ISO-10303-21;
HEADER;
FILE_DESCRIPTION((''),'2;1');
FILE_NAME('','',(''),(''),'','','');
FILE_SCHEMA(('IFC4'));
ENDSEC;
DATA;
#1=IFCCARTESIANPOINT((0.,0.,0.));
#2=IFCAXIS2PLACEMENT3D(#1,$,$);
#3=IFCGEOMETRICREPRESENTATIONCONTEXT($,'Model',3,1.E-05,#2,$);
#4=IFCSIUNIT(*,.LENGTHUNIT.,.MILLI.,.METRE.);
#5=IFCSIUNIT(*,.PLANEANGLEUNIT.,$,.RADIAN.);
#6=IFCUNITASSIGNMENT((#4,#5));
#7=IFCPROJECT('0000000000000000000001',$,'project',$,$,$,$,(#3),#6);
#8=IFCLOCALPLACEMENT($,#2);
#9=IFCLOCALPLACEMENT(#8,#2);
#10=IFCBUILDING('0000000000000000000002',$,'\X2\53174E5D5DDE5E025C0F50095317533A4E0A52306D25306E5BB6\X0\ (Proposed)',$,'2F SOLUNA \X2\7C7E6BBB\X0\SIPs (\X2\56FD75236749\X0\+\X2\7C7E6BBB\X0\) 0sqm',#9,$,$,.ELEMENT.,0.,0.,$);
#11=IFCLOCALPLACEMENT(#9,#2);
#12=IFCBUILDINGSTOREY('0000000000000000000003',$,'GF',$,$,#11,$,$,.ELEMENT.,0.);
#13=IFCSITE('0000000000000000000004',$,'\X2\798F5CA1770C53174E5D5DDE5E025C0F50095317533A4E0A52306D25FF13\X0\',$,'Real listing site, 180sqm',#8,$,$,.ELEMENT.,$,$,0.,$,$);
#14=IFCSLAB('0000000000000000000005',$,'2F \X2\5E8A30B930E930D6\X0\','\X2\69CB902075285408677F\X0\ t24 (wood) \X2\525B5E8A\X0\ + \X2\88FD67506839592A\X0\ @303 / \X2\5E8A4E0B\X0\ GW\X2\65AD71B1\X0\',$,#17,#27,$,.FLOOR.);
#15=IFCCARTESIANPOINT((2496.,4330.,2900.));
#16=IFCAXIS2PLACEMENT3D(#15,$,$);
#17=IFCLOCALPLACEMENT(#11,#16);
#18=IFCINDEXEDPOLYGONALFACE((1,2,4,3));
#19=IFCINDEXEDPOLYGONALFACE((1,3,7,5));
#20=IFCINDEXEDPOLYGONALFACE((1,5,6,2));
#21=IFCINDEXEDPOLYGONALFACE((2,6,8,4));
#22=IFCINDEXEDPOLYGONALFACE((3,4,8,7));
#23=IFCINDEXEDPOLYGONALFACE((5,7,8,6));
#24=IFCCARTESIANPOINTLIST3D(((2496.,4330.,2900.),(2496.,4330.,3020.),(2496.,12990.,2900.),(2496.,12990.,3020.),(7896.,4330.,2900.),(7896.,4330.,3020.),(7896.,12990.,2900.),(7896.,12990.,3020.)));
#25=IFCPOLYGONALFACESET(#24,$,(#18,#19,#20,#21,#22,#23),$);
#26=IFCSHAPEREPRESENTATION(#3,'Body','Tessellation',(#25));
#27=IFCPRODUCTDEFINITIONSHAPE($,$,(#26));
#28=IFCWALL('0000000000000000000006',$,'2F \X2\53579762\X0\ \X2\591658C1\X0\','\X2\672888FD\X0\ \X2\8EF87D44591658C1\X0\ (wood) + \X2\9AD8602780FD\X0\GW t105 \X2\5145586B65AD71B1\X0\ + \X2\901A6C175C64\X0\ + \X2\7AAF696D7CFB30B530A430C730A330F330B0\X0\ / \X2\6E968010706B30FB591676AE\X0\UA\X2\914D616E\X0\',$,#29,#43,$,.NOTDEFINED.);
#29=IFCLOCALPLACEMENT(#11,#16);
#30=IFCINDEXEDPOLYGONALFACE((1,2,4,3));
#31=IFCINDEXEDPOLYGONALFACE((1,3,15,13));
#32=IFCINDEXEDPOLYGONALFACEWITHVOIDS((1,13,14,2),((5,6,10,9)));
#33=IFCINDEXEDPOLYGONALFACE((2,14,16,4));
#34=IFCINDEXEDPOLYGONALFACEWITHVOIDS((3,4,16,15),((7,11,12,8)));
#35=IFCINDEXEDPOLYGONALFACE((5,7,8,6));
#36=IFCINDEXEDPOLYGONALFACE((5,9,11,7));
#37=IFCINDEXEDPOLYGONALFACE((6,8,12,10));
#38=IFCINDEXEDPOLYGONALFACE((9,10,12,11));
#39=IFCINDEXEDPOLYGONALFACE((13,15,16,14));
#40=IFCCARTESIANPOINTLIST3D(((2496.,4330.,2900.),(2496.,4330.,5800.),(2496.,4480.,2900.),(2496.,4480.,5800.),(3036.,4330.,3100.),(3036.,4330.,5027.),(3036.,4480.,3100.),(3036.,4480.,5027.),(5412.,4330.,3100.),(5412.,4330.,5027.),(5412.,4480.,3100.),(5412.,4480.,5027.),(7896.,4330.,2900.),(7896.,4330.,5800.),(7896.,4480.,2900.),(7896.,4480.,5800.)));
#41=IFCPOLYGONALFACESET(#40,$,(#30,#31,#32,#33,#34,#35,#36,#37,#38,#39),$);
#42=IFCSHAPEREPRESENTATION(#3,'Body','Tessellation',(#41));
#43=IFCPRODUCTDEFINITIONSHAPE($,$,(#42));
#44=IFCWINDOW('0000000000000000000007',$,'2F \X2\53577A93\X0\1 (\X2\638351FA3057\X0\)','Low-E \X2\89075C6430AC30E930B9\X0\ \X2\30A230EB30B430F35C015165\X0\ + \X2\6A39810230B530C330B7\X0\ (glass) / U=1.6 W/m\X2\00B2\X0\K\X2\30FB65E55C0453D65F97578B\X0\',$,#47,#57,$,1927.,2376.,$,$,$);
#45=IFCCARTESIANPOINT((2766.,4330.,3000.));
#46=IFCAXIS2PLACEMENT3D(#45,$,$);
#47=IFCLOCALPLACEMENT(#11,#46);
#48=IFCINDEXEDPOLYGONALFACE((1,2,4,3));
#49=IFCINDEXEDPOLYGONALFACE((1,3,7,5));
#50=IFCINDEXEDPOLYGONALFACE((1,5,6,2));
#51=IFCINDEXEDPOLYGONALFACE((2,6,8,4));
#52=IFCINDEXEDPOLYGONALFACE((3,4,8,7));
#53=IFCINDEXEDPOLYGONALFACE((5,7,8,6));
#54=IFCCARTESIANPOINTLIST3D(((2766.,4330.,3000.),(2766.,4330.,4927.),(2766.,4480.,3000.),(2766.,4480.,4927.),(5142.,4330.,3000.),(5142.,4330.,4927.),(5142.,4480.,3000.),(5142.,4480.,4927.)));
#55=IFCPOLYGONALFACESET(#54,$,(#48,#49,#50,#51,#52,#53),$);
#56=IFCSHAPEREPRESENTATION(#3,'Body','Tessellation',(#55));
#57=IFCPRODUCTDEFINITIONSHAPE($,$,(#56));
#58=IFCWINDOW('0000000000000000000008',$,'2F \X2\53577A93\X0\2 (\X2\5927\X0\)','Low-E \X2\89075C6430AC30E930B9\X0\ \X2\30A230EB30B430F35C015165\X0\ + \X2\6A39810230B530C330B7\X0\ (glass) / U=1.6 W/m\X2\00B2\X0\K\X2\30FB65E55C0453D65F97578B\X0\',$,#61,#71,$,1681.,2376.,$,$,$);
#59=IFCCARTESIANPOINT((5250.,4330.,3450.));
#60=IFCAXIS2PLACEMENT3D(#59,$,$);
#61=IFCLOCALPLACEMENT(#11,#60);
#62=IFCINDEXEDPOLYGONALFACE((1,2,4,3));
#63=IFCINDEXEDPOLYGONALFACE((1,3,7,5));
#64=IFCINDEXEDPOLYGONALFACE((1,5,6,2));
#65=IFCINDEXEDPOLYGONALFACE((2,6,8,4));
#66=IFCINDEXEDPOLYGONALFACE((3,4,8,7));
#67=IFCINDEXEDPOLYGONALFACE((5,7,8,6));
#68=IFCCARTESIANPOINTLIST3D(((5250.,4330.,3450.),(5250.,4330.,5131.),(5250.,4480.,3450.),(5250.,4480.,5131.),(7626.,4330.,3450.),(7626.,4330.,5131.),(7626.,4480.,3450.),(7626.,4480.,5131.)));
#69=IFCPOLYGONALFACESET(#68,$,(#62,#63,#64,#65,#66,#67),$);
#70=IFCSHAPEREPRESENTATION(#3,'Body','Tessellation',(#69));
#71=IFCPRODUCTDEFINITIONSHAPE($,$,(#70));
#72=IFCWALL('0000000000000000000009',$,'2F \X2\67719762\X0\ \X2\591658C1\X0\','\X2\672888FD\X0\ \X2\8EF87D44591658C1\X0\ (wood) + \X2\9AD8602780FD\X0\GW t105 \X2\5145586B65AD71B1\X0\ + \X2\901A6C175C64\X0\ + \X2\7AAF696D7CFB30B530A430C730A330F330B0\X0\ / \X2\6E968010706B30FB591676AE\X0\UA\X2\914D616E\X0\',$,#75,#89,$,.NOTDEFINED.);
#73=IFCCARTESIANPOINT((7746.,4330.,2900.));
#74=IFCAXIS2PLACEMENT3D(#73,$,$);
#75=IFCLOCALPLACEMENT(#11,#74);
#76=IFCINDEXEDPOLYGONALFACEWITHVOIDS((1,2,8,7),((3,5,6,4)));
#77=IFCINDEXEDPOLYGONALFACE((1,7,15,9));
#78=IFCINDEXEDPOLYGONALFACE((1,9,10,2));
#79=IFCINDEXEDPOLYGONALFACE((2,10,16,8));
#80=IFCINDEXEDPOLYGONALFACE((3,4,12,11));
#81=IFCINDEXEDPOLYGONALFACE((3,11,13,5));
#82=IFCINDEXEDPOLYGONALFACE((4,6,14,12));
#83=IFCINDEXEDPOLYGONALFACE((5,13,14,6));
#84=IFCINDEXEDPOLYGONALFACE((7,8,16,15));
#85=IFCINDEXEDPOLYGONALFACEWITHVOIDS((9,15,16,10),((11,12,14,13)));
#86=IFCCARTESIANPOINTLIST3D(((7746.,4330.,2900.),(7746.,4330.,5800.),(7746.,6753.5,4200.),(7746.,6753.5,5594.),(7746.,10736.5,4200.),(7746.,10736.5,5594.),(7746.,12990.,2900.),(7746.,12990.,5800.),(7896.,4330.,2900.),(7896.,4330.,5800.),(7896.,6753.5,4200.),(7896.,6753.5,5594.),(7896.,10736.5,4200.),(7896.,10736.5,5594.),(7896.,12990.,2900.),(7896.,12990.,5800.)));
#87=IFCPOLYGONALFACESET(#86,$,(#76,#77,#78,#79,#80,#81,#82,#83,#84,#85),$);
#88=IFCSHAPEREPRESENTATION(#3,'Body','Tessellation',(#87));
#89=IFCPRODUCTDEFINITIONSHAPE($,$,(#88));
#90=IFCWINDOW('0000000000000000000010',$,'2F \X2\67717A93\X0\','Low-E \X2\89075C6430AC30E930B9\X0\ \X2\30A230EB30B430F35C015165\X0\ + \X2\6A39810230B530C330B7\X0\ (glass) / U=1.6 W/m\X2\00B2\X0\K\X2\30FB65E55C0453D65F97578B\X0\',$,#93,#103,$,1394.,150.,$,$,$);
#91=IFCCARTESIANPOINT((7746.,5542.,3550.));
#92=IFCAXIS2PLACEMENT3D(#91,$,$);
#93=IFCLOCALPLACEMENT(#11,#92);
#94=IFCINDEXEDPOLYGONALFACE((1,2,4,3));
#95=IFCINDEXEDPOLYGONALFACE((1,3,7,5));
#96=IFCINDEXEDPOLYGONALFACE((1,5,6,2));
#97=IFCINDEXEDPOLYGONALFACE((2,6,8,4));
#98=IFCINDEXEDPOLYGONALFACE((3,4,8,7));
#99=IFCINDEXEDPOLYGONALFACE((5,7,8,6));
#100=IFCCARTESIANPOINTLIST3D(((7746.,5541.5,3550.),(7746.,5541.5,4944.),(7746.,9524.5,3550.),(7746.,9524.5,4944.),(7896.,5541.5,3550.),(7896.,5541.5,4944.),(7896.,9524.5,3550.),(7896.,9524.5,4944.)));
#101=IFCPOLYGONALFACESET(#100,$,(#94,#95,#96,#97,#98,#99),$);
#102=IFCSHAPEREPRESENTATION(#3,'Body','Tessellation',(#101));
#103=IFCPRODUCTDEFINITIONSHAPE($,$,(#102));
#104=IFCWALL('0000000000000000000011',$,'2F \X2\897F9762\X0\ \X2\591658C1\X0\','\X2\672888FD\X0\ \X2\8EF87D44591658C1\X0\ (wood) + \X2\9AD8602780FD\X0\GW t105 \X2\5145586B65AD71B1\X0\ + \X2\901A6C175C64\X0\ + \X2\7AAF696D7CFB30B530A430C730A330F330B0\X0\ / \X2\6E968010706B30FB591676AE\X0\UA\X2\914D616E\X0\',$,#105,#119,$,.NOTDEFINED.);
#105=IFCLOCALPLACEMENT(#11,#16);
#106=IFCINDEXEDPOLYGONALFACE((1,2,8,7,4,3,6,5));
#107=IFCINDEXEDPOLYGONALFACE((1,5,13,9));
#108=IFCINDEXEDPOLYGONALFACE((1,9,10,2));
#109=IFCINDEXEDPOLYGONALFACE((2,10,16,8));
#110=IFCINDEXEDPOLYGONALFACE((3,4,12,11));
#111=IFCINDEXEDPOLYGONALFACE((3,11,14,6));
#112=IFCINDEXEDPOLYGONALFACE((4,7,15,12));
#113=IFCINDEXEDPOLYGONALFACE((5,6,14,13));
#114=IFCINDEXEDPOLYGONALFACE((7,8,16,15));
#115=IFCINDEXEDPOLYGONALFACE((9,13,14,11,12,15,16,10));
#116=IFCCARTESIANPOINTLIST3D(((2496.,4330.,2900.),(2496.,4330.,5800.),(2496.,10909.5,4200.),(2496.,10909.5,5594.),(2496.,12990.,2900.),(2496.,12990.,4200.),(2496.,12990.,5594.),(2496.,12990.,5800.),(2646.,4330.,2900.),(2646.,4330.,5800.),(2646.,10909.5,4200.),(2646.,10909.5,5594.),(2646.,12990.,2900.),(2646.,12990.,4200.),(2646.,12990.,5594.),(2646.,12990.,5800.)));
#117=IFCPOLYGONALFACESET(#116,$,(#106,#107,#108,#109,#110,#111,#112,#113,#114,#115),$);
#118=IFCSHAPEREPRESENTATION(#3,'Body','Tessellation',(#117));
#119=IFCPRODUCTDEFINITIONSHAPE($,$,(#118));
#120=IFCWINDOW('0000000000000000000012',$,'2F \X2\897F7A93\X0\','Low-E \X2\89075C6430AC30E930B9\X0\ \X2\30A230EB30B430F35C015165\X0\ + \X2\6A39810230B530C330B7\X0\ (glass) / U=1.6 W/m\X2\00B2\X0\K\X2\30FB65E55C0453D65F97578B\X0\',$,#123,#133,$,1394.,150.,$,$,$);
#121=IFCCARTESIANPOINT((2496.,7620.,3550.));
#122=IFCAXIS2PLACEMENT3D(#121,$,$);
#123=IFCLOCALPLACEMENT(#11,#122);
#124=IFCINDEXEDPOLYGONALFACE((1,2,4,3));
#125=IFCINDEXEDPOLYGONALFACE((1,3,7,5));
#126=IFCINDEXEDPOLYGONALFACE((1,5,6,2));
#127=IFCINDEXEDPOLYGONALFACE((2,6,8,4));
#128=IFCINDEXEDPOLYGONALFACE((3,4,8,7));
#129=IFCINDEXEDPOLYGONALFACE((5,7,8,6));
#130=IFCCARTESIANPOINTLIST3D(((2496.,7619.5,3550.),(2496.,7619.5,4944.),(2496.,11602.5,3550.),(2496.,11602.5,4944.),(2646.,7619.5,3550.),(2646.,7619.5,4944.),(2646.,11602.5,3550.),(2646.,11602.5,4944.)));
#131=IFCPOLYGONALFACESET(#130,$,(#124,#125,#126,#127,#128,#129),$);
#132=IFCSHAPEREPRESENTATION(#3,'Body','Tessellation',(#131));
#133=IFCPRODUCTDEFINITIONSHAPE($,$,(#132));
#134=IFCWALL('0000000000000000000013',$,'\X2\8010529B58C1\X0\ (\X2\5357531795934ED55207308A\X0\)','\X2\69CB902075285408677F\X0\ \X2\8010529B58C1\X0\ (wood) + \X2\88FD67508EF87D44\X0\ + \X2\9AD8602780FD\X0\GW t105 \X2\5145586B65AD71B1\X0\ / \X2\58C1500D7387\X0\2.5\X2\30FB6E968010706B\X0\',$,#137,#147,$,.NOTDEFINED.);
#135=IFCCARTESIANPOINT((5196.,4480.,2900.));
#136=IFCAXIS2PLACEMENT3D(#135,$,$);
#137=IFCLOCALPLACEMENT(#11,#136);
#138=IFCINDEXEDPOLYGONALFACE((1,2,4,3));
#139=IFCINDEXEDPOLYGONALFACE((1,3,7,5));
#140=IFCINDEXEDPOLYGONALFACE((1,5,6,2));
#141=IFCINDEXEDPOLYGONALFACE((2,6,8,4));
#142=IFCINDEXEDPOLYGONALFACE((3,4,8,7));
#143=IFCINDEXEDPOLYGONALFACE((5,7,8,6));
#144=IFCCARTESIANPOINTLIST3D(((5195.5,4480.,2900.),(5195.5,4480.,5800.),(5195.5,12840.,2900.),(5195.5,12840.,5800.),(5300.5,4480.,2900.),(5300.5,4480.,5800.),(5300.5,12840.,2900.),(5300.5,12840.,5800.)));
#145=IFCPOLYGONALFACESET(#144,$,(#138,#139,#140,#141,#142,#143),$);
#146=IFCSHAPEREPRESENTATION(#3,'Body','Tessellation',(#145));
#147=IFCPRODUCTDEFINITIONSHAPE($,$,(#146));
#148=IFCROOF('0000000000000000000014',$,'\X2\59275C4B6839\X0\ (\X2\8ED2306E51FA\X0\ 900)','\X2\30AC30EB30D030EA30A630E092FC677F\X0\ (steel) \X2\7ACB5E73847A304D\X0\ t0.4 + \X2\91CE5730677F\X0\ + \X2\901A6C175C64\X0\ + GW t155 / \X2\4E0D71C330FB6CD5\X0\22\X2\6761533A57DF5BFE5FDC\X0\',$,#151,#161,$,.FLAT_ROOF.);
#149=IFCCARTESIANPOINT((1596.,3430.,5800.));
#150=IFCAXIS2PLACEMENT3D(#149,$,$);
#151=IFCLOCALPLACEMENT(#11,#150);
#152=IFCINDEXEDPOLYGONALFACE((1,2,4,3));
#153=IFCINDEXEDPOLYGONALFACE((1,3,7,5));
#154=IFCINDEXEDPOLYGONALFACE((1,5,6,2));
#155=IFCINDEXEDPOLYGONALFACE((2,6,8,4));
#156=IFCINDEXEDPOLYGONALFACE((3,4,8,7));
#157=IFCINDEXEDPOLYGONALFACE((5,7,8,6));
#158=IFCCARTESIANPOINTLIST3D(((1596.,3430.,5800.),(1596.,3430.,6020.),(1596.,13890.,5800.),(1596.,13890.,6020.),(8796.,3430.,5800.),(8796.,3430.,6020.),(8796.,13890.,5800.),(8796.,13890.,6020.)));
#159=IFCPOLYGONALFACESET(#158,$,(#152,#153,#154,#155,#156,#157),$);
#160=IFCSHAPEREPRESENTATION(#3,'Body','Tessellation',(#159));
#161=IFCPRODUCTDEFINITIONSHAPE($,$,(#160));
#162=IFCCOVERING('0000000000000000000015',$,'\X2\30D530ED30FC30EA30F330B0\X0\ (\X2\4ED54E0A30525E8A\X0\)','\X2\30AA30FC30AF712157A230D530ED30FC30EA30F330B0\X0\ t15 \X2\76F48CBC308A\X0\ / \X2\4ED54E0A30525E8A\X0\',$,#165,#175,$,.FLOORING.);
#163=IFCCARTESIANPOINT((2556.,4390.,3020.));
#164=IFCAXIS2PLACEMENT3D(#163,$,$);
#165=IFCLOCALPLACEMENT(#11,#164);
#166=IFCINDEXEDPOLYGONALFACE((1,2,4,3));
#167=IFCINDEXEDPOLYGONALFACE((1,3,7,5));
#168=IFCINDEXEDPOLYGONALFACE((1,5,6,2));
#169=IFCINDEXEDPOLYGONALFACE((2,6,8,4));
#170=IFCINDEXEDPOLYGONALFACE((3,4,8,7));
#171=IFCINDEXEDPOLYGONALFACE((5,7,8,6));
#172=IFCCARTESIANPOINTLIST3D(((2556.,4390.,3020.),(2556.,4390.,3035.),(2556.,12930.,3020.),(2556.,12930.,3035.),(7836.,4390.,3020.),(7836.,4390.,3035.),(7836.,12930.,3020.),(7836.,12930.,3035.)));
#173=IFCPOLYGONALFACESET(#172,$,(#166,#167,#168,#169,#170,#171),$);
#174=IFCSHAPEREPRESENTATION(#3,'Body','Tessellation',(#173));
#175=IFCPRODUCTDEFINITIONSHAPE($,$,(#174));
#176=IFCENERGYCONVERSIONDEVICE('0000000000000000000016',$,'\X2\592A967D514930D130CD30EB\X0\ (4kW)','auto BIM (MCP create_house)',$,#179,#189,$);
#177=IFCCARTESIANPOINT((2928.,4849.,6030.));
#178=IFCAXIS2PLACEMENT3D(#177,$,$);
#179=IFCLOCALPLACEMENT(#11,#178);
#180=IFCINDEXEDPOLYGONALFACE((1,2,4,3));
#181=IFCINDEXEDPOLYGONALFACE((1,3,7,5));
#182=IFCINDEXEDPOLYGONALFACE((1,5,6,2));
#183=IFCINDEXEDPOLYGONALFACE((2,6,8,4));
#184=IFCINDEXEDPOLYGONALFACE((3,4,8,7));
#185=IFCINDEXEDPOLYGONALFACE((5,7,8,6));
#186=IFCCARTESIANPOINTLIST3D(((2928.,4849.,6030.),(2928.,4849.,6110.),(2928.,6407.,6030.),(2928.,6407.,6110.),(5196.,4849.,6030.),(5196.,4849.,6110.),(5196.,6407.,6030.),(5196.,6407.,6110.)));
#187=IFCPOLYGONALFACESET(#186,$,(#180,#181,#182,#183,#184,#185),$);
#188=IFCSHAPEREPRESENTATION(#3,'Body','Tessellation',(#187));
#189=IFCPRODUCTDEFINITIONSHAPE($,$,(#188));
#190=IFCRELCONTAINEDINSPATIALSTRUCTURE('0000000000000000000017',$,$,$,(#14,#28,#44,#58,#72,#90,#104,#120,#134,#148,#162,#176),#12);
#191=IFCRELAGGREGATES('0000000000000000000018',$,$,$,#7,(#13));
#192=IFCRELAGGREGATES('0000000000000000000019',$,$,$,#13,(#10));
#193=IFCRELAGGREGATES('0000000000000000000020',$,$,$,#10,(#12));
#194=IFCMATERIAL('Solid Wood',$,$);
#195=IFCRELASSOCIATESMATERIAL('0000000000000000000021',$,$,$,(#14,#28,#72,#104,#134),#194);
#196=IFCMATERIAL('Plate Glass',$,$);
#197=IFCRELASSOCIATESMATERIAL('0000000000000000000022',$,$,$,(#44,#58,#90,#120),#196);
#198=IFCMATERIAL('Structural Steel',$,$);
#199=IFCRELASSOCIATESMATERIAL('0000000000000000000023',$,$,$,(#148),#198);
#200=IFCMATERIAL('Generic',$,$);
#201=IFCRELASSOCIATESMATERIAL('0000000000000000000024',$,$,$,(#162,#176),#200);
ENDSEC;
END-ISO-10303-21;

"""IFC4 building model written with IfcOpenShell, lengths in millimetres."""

from ifc_helpers import new_model, si_unit, frame, frame_2d, origin, place, context, project, spatial, rectangle, extrude, material, element, fill, save


model = new_model("IFC4")

# Units and contexts
model_context = context("Model", 3, precision=1e-05, world=origin())
ifc_project = project(units=[si_unit("LENGTHUNIT", "METRE", prefix="MILLI"), si_unit("PLANEANGLEUNIT", "RADIAN")], contexts=[model_context])

# Site, building, storey
site_placement = place(None, origin())
site = spatial("IfcSite", under=ifc_project, at=site_placement, Name="福岡県北九州市小倉北区上到津３", ObjectType="Real listing site, 180sqm", CompositionType="ELEMENT", RefElevation=0.0)
building_placement = place(site_placement, origin())
building = spatial("IfcBuilding", under=site, at=building_placement, Name="北九州市小倉北区上到津の家 (Proposed)", ObjectType="2F SOLUNA 籾殻SIPs (国産杉+籾殻) 0sqm", CompositionType="ELEMENT", ElevationOfRefHeight=0.0, ElevationOfTerrain=0.0)
storey_placement = place(building_placement, origin())
storey = spatial("IfcBuildingStorey", under=building, at=storey_placement, Name="GF", CompositionType="ELEMENT", Elevation=0.0)

# Slab
ifc_material_1 = material(Name="Solid Wood")
slab_placement = place(storey_placement, frame((2496.0, 4330.0, 2900.0)))
element("IfcSlab", 1, at=slab_placement, inside=storey, material=ifc_material_1, Name="2F 床スラブ", Description="構造用合板 t24 (wood) 剛床 + 製材根太 @303 / 床下 GW断熱", PredefinedType="FLOOR", context=model_context, shape_type="SweptSolid", body=[
    extrude(rectangle(XDim=5400.0, YDim=8660.0, at=frame_2d((2700.0, 4330.0))), frame((2496.0, 4330.0, 2900.0)), (0.0, 0.0, 1.0), 120.0),
])

# Wall, openings, windows
wall_1_placement = place(storey_placement, frame((2496.0, 4330.0, 2900.0)))
wall_1 = element("IfcWall", 2, at=wall_1_placement, inside=storey, material=ifc_material_1, Name="2F 南面 外壁", Description="木製 軸組外壁 (wood) + 高性能GW t105 充填断熱 + 通気層 + 窯業系サイディング / 準耐火・外皮UA配慮", PredefinedType="NOTDEFINED", context=model_context, shape_type="SweptSolid", body=[
    extrude(rectangle(XDim=5400.0, YDim=150.0, at=frame_2d((2700.0, 75.0))), frame((2496.0, 4330.0, 2900.0)), (0.0, 0.0, 1.0), 2900.0),
])
opening_1_placement = place(storey_placement, frame((2766.0, 4330.0, 3000.0)))
opening_1 = element("IfcOpeningElement", 3, at=opening_1_placement, cuts=wall_1, PredefinedType="NOTDEFINED", context=model_context, shape_type="SweptSolid", body=[
    extrude(rectangle(XDim=2376.0, YDim=150.0, at=frame_2d((1188.0, 75.0))), frame((2766.0, 4330.0, 3000.0)), (0.0, 0.0, 1.0), 1927.0),
])
opening_2_placement = place(storey_placement, frame((5250.0, 4330.0, 3450.0)))
opening_2 = element("IfcOpeningElement", 4, at=opening_2_placement, cuts=wall_1, PredefinedType="NOTDEFINED", context=model_context, shape_type="SweptSolid", body=[
    extrude(rectangle(XDim=2376.0, YDim=150.0, at=frame_2d((1188.0, 75.0))), frame((5250.0, 4330.0, 3450.0)), (0.0, 0.0, 1.0), 1681.0),
])
ifc_material_2 = material(Name="Plate Glass")
window_1_placement = place(storey_placement, frame((2766.0, 4330.0, 3000.0)))
window_1 = element("IfcWindow", 5, at=window_1_placement, inside=storey, material=ifc_material_2, Name="2F 南窓1 (掃出し)", Description="Low-E 複層ガラス アルゴン封入 + 樹脂サッシ (glass) / U=1.6 W/m²K・日射取得型", OverallHeight=1927.0, OverallWidth=2376.0, context=model_context, shape_type="SweptSolid", body=[
    extrude(rectangle(XDim=2376.0, YDim=150.0, at=frame_2d((1188.0, 75.0))), frame((2766.0, 4330.0, 3000.0)), (0.0, 0.0, 1.0), 1927.0),
])
fill(opening_1, window_1)
window_2_placement = place(storey_placement, frame((5250.0, 4330.0, 3450.0)))
window_2 = element("IfcWindow", 6, at=window_2_placement, inside=storey, material=ifc_material_2, Name="2F 南窓2 (大)", Description="Low-E 複層ガラス アルゴン封入 + 樹脂サッシ (glass) / U=1.6 W/m²K・日射取得型", OverallHeight=1681.0, OverallWidth=2376.0, context=model_context, shape_type="SweptSolid", body=[
    extrude(rectangle(XDim=2376.0, YDim=150.0, at=frame_2d((1188.0, 75.0))), frame((5250.0, 4330.0, 3450.0)), (0.0, 0.0, 1.0), 1681.0),
])
fill(opening_2, window_2)

# Walls, openings, windows
wall_2_placement = place(storey_placement, frame((7746.0, 4330.0, 2900.0)))
wall_2 = element("IfcWall", 7, at=wall_2_placement, inside=storey, material=ifc_material_1, Name="2F 東面 外壁", Description="木製 軸組外壁 (wood) + 高性能GW t105 充填断熱 + 通気層 + 窯業系サイディング / 準耐火・外皮UA配慮", PredefinedType="NOTDEFINED", context=model_context, shape_type="SweptSolid", body=[
    extrude(rectangle(XDim=150.0, YDim=8660.0, at=frame_2d((75.0, 4330.0))), frame((7746.0, 4330.0, 2900.0)), (0.0, 0.0, 1.0), 2900.0),
])
opening_3_placement = place(storey_placement, frame((7746.0, 5542.0, 3550.0)))
opening_3 = element("IfcOpeningElement", 8, at=opening_3_placement, cuts=wall_2, PredefinedType="NOTDEFINED", context=model_context, shape_type="SweptSolid", body=[
    extrude(rectangle(XDim=150.0, YDim=3983.0, at=frame_2d((75.0, 1991.0))), frame((7746.0, 5542.0, 3550.0)), (0.0, 0.0, 1.0), 1394.0),
])
window_3_placement = place(storey_placement, frame((7746.0, 5542.0, 3550.0)))
window_3 = element("IfcWindow", 9, at=window_3_placement, inside=storey, material=ifc_material_2, Name="2F 東窓", Description="Low-E 複層ガラス アルゴン封入 + 樹脂サッシ (glass) / U=1.6 W/m²K・日射取得型", OverallHeight=1394.0, OverallWidth=150.0, context=model_context, shape_type="SweptSolid", body=[
    extrude(rectangle(XDim=150.0, YDim=3983.0, at=frame_2d((75.0, 1991.0))), frame((7746.0, 5542.0, 3550.0)), (0.0, 0.0, 1.0), 1394.0),
])
fill(opening_3, window_3)
wall_3_placement = place(storey_placement, frame((2496.0, 4330.0, 2900.0)))
wall_3 = element("IfcWall", 10, at=wall_3_placement, inside=storey, material=ifc_material_1, Name="2F 西面 外壁", Description="木製 軸組外壁 (wood) + 高性能GW t105 充填断熱 + 通気層 + 窯業系サイディング / 準耐火・外皮UA配慮", PredefinedType="NOTDEFINED", context=model_context, shape_type="SweptSolid", body=[
    extrude(rectangle(XDim=150.0, YDim=8660.0, at=frame_2d((75.0, 4330.0))), frame((2496.0, 4330.0, 2900.0)), (0.0, 0.0, 1.0), 2900.0),
])
opening_4_placement = place(storey_placement, frame((2496.0, 7620.0, 3550.0)))
opening_4 = element("IfcOpeningElement", 11, at=opening_4_placement, cuts=wall_3, PredefinedType="NOTDEFINED", context=model_context, shape_type="SweptSolid", body=[
    extrude(rectangle(XDim=150.0, YDim=3983.0, at=frame_2d((75.0, 1991.0))), frame((2496.0, 7620.0, 3550.0)), (0.0, 0.0, 1.0), 1394.0),
])
window_4_placement = place(storey_placement, frame((2496.0, 7620.0, 3550.0)))
window_4 = element("IfcWindow", 12, at=window_4_placement, inside=storey, material=ifc_material_2, Name="2F 西窓", Description="Low-E 複層ガラス アルゴン封入 + 樹脂サッシ (glass) / U=1.6 W/m²K・日射取得型", OverallHeight=1394.0, OverallWidth=150.0, context=model_context, shape_type="SweptSolid", body=[
    extrude(rectangle(XDim=150.0, YDim=3983.0, at=frame_2d((75.0, 1991.0))), frame((2496.0, 7620.0, 3550.0)), (0.0, 0.0, 1.0), 1394.0),
])
fill(opening_4, window_4)

# Wall
wall_4_placement = place(storey_placement, frame((5196.0, 4480.0, 2900.0)))
element("IfcWall", 13, at=wall_4_placement, inside=storey, material=ifc_material_1, Name="耐力壁 (南北間仕切り)", Description="構造用合板 耐力壁 (wood) + 製材軸組 + 高性能GW t105 充填断熱 / 壁倍率2.5・準耐火", PredefinedType="NOTDEFINED", context=model_context, shape_type="SweptSolid", body=[
    extrude(rectangle(XDim=105.0, YDim=8360.0, at=frame_2d((52.0, 4180.0))), frame((5196.0, 4480.0, 2900.0)), (0.0, 0.0, 1.0), 2900.0),
])

# Roof
ifc_material_3 = material(Name="Structural Steel")
roof_placement = place(storey_placement, frame((1596.0, 3430.0, 5800.0)))
element("IfcRoof", 14, at=roof_placement, inside=storey, material=ifc_material_3, Name="大屋根 (軒の出 900)", Description="ガルバリウム鋼板 (steel) 立平葺き t0.4 + 野地板 + 通気層 + GW t155 / 不燃・法22条区域対応", PredefinedType="FLAT_ROOF", context=model_context, shape_type="SweptSolid", body=[
    extrude(rectangle(XDim=7200.0, YDim=10460.0, at=frame_2d((3600.0, 5230.0))), frame((1596.0, 3430.0, 5800.0)), (0.0, 0.0, 1.0), 220.0),
])

# Covering
ifc_material_4 = material(Name="Generic")
covering_placement = place(storey_placement, frame((2556.0, 4390.0, 3020.0)))
element("IfcCovering", 15, at=covering_placement, inside=storey, material=ifc_material_4, Name="フローリング (仕上げ床)", Description="オーク無垢フローリング t15 直貼り / 仕上げ床", PredefinedType="FLOORING", context=model_context, shape_type="SweptSolid", body=[
    extrude(rectangle(XDim=5280.0, YDim=8540.0, at=frame_2d((2640.0, 4270.0))), frame((2556.0, 4390.0, 3020.0)), (0.0, 0.0, 1.0), 15.0),
])

# Energy conversion device
energy_conversion_device_placement = place(storey_placement, frame((2928.0, 4849.0, 6030.0)))
element("IfcEnergyConversionDevice", 16, at=energy_conversion_device_placement, inside=storey, material=ifc_material_4, Name="太陽光パネル (4kW)", Description="auto BIM (MCP create_house)", context=model_context, shape_type="SweptSolid", body=[
    extrude(rectangle(XDim=2268.0, YDim=1558.0, at=frame_2d((1134.0, 779.0))), frame((2928.0, 4849.0, 6030.0)), (0.0, 0.0, 1.0), 80.0),
])

save(model, "model.ifc")
